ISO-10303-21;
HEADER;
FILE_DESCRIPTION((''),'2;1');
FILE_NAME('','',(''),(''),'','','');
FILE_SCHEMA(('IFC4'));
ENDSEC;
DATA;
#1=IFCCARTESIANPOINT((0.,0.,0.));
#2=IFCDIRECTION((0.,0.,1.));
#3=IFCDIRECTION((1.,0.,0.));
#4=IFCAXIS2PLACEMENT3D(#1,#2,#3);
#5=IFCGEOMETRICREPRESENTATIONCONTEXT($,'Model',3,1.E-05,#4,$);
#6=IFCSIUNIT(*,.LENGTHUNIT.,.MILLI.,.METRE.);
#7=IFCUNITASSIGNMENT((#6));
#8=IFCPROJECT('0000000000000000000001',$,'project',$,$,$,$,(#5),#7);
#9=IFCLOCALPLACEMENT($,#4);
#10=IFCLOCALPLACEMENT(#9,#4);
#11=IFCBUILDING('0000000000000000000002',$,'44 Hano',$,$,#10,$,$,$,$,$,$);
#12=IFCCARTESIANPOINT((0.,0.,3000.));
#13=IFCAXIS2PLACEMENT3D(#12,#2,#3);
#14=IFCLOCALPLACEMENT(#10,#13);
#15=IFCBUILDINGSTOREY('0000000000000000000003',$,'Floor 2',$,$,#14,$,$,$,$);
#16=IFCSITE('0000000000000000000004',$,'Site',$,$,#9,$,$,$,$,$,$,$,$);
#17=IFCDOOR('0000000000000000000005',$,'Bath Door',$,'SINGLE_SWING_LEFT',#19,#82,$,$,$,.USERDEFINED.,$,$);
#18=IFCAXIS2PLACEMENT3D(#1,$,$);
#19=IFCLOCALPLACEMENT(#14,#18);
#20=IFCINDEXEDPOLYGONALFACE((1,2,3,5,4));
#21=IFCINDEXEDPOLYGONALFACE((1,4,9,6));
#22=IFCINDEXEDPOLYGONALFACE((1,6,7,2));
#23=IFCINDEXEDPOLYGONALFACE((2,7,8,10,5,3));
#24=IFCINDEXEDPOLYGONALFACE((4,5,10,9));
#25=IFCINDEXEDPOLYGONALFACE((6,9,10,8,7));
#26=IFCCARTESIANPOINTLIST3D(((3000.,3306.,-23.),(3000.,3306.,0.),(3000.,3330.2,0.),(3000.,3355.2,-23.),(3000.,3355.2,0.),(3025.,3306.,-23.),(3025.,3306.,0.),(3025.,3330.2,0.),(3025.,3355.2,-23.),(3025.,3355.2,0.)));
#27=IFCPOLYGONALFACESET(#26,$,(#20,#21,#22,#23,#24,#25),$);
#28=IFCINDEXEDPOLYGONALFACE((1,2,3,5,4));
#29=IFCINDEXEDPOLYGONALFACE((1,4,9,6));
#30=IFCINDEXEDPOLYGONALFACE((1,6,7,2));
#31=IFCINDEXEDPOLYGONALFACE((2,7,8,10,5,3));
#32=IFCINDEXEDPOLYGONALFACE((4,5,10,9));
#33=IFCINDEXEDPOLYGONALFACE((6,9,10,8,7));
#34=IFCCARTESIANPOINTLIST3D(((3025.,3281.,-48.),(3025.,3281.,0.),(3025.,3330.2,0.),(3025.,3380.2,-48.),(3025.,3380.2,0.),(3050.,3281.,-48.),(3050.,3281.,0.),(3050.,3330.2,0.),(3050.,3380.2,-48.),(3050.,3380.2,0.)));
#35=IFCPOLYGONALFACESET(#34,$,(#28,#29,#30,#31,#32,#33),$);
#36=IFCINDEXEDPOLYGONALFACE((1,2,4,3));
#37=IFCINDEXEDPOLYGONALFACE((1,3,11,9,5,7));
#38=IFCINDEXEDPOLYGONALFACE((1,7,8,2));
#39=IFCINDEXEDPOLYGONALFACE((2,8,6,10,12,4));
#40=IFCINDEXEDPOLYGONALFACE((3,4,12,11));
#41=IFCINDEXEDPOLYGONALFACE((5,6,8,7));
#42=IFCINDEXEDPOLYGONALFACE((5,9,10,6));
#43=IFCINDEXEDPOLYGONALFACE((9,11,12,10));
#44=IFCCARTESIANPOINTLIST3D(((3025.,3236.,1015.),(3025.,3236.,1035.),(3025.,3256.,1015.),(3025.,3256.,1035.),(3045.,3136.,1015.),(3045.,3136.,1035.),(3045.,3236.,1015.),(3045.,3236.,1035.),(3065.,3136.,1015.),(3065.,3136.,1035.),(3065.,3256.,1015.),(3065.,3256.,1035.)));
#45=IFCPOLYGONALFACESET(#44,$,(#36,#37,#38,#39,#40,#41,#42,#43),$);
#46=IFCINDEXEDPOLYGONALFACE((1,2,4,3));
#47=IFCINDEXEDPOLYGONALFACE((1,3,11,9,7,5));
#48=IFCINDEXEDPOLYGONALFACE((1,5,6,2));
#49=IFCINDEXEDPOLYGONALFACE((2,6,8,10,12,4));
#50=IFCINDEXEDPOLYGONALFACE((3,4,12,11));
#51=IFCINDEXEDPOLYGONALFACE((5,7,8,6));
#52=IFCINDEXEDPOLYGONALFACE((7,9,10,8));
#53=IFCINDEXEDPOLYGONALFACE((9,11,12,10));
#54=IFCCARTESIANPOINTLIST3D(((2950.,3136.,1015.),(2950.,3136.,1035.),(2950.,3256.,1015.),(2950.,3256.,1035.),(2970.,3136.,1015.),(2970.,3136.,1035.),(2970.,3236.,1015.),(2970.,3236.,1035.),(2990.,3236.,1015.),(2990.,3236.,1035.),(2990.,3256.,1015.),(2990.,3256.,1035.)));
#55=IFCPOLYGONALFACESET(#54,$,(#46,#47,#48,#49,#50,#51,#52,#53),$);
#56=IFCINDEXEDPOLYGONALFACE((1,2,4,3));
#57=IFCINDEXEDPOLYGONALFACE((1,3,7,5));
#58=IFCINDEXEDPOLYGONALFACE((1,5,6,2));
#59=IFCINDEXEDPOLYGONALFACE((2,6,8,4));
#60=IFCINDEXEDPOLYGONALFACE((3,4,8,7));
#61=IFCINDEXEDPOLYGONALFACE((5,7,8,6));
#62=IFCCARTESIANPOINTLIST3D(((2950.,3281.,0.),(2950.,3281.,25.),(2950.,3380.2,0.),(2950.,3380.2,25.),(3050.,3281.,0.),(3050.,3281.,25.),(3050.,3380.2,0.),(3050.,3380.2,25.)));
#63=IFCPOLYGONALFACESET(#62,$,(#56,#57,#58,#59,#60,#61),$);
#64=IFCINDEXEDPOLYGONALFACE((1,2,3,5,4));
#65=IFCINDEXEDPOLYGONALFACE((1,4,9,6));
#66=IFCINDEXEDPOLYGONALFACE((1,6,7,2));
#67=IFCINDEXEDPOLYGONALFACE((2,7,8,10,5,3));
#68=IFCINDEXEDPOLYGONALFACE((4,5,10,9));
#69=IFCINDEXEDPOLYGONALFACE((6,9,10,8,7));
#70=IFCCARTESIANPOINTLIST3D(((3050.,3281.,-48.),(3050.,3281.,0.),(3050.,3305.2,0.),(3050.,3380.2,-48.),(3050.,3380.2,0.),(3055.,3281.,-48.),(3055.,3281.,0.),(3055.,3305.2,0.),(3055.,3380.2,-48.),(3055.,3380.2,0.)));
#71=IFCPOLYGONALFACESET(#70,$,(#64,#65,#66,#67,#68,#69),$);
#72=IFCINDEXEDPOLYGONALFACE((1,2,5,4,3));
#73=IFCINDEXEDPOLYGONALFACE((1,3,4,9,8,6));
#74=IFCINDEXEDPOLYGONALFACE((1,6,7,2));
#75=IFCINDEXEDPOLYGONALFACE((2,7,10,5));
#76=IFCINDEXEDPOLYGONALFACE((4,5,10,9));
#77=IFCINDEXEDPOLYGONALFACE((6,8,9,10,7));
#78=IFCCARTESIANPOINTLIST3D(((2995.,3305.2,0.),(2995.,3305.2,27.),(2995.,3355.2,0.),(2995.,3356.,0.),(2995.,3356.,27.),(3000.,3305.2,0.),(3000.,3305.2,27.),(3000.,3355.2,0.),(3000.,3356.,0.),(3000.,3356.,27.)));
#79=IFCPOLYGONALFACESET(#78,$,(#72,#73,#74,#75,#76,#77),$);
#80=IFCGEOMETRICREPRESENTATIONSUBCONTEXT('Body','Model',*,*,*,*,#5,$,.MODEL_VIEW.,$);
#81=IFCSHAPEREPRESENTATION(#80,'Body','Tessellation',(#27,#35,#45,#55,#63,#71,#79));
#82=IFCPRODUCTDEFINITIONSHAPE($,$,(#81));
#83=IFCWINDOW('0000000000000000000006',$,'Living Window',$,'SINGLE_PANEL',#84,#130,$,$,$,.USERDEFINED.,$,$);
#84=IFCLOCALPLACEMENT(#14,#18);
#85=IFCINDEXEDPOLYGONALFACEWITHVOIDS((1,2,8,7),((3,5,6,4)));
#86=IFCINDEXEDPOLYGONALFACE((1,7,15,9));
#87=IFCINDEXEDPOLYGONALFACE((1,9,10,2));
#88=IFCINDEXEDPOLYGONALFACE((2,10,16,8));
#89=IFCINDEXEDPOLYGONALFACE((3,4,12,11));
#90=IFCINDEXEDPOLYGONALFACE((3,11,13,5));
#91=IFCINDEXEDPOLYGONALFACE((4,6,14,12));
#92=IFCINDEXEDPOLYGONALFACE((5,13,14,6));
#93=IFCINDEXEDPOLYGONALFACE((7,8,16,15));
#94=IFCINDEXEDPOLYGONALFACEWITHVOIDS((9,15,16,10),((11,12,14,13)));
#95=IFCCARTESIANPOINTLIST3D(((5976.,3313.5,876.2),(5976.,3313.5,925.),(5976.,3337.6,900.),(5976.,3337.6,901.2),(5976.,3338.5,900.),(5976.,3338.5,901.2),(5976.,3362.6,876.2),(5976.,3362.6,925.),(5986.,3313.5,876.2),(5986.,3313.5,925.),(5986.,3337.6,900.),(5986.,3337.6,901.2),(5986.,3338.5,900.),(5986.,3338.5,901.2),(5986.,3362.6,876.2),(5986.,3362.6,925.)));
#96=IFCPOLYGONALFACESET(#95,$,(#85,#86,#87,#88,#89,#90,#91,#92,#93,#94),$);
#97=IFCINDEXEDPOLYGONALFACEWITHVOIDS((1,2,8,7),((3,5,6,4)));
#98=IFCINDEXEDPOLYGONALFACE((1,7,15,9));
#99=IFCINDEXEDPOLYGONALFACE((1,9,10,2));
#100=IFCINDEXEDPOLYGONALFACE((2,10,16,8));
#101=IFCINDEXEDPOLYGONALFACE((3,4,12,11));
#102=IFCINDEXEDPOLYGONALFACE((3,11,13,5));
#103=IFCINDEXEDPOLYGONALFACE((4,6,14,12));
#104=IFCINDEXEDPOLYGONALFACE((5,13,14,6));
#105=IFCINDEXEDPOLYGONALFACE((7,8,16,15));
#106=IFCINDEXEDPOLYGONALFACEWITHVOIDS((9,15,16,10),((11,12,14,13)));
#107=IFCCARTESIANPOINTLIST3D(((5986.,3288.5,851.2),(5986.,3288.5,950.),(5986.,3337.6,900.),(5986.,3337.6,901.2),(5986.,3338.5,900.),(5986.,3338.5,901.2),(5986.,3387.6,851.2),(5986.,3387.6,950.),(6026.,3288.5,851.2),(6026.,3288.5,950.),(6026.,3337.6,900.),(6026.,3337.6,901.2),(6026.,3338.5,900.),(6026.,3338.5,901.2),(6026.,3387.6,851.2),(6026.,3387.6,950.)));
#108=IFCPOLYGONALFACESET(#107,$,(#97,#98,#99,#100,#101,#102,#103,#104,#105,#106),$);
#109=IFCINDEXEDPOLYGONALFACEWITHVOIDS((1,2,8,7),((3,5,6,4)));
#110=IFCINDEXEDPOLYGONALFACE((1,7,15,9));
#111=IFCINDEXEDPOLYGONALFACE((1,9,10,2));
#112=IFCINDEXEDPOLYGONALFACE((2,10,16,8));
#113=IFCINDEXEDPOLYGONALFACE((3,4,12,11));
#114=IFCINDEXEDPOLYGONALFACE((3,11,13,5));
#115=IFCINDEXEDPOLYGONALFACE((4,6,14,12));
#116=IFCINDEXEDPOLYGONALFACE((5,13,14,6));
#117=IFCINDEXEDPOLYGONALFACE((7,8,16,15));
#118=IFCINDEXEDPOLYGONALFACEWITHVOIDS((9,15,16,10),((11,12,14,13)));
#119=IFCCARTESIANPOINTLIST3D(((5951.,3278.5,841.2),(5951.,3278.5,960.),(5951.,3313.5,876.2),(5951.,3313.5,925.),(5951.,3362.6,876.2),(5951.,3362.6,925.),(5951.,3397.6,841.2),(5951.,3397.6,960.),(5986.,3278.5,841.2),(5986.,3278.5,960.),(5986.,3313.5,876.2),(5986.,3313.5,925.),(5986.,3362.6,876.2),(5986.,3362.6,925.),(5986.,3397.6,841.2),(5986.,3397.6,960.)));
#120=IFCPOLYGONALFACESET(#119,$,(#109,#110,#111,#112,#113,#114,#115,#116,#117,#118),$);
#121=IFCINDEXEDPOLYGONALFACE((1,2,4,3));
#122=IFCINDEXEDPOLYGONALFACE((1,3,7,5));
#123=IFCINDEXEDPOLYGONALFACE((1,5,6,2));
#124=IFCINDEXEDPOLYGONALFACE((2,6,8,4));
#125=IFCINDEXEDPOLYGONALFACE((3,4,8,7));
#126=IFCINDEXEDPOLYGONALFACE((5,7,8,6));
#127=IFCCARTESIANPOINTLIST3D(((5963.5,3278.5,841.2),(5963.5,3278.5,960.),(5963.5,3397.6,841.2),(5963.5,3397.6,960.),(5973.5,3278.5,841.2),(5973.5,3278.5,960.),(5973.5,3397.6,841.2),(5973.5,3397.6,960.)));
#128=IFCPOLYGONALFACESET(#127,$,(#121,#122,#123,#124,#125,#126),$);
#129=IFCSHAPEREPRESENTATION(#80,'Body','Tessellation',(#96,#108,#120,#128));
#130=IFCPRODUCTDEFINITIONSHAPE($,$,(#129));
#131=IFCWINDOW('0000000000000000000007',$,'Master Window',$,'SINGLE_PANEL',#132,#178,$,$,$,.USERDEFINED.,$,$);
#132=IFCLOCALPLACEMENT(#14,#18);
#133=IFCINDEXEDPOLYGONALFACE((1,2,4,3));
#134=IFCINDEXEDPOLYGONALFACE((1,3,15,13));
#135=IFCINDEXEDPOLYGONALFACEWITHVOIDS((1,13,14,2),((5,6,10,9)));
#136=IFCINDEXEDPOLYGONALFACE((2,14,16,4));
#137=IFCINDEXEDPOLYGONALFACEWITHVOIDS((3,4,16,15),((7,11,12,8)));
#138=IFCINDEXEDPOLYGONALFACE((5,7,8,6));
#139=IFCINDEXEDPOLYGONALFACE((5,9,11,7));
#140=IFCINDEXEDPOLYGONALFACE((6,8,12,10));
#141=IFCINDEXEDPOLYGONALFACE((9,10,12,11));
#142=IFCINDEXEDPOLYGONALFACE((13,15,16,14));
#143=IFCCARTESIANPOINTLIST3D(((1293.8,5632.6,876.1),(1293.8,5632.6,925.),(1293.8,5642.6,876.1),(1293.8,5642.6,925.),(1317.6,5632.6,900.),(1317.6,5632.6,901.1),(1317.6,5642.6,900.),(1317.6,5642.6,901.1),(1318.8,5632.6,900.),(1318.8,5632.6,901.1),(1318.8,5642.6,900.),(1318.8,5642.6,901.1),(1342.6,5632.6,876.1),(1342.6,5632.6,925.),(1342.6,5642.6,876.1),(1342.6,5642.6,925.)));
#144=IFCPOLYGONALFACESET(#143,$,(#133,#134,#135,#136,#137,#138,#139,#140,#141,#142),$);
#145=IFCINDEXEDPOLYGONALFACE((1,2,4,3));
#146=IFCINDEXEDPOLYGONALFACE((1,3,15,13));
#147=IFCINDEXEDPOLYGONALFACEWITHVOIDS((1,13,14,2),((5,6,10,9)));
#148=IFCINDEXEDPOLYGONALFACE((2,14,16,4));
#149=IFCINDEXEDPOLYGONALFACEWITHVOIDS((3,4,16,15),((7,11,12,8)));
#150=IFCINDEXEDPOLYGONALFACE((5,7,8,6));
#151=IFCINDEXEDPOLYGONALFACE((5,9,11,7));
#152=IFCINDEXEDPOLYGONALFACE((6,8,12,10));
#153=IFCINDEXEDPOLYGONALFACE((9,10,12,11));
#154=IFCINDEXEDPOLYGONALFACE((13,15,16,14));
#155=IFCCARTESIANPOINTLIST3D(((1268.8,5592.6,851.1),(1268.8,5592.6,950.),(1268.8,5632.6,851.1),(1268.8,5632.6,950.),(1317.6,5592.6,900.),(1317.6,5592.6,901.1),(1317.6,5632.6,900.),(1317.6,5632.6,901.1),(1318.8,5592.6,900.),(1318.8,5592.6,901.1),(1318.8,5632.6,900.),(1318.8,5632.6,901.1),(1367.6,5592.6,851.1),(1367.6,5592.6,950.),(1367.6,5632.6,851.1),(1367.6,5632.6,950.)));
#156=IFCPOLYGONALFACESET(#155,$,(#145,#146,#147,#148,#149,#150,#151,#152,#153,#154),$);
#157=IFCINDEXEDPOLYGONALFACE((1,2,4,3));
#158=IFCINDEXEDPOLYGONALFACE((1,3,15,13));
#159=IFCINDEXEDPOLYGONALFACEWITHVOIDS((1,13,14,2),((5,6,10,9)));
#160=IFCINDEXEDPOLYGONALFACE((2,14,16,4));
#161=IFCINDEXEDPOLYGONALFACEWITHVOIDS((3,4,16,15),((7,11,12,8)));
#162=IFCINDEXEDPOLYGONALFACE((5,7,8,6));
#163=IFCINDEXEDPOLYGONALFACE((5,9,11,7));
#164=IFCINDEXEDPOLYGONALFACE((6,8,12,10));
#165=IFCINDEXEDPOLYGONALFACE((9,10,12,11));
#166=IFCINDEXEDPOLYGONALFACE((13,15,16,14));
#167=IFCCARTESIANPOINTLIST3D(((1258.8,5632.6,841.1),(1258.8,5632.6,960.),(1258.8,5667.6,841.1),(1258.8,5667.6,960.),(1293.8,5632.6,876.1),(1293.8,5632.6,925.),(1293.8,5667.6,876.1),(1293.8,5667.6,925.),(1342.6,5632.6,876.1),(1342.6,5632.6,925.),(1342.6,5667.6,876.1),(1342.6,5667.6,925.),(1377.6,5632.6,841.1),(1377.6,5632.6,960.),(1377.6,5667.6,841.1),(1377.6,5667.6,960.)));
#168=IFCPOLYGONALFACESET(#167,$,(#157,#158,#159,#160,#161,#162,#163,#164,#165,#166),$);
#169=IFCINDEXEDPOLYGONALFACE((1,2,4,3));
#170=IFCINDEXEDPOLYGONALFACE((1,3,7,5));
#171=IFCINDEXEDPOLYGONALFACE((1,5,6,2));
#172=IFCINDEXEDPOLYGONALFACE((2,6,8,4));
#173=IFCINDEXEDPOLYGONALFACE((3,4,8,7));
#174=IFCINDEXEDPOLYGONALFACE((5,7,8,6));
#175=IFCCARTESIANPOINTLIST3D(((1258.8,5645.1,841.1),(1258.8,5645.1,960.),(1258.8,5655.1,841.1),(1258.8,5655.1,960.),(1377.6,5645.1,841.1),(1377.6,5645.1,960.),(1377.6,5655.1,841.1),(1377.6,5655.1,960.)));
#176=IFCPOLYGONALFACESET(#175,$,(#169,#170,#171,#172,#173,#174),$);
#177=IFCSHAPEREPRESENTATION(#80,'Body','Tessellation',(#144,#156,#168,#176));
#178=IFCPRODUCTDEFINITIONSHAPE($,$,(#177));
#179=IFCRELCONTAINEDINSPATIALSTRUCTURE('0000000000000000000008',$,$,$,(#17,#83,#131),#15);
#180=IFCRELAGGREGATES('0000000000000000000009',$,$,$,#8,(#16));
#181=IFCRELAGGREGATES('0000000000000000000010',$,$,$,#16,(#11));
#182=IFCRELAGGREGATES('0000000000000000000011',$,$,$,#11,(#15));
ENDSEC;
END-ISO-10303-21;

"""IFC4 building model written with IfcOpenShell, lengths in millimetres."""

from ifc_helpers import new_model, si_unit, frame, origin_with_axes, place, context, subcontext, project, spatial, line, indexed_curve, outline, extrude, element, save


model = new_model("IFC4")

# Units and contexts
model_context = context("Model", 3, precision=1e-05, world=origin_with_axes())
body_context = subcontext(model_context, "Body", "Model", "MODEL_VIEW")
ifc_project = project(units=[si_unit("LENGTHUNIT", "METRE", prefix="MILLI")], contexts=[model_context])

# Site, building, storey
site_placement = place(None, origin_with_axes())
site = spatial("IfcSite", under=ifc_project, at=site_placement, Name="Site")
building_placement = place(site_placement, origin_with_axes())
building = spatial("IfcBuilding", under=site, at=building_placement, Name="44 Hano")
storey_placement = place(building_placement, frame((0.0, 0.0, 3000.0), z_axis=(0.0, 0.0, 1.0), x_axis=(1.0, 0.0, 0.0)))
storey = spatial("IfcBuildingStorey", under=building, at=storey_placement, Name="Floor 2")

# Door
door_1_placement = place(storey_placement, frame((3050.0, 3330.2, 0.0), z_axis=(0.0, 0.0, 1.0), x_axis=(0.0, 1.0, 0.0)))
element("IfcDoor", 1, at=door_1_placement, inside=storey, Name="Bath Door", ObjectType="SINGLE_SWING_LEFT", PredefinedType="USERDEFINED", context=body_context, shape_type="SweptSolid", body=[
    extrude(outline(indexed_curve([(0.0, 0.0), (0.0, 2.0), (0.8, 2.0), (0.8, 0.0), (-24.2, 0.0), (-24.2, -23.0), (25.0, -23.0), (25.0, 0.0)], segments=[line(1, 2, 3, 4, 5, 6, 7, 8, 1)])), frame((0.0, 25.0, 0.0), z_axis=(0.0, -1.0, 0.0), x_axis=(1.0, 0.0, 0.0)), (0.0, 0.0, -1.0), 25.0),
    extrude(outline(indexed_curve([(0.0, 0.0), (0.0, 2.0), (0.8, 2.0), (0.8, 0.0), (-49.2, 0.0), (-49.2, -48.0), (50.0, -48.0), (50.0, 0.0)], segments=[line(1, 2, 3, 4, 5, 6, 7, 8, 1)])), frame((0.0, 0.0, 0.0), z_axis=(0.0, -1.0, 0.0), x_axis=(1.0, 0.0, 0.0)), (0.0, 0.0, -1.0), 25.0),
    extrude(outline(indexed_curve([(0.0, 0.0), (-49.2, 0.0), (-49.2, 35.0), (0.0, 35.0)], segments=[line(1, 2, 3, 4, 1)])), frame((25.0, 25.0, 25.0), z_axis=(0.0, 0.0, 1.0), x_axis=(1.0, 0.0, 0.0)), (0.0, 0.0, 1.0), -48.0),
    extrude(outline(indexed_curve([(0.0, 0.0), (0.0, -40.0), (-120.0, -40.0), (-120.0, -20.0), (-20.0, -20.0), (-20.0, 0.0)], segments=[line(1, 2, 3, 4, 5, 6, 1)])), frame((-74.2, 25.0, 1015.0), z_axis=(0.0, 0.0, 1.0), x_axis=(1.0, 0.0, 0.0)), (0.0, 0.0, 1.0), 20.0),
    extrude(outline(indexed_curve([(0.0, 0.0), (0.0, 40.0), (-120.0, 40.0), (-120.0, 20.0), (-20.0, 20.0), (-20.0, 0.0)], segments=[line(1, 2, 3, 4, 5, 6, 1)])), frame((-74.2, 60.0, 1015.0), z_axis=(0.0, 0.0, 1.0), x_axis=(1.0, 0.0, 0.0)), (0.0, 0.0, 1.0), 20.0),
    extrude(outline(indexed_curve([(0.0, 0.0), (-99.2, 0.0), (-99.2, 100.0), (0.0, 100.0)], segments=[line(1, 2, 3, 4, 1)])), frame((50.0, 0.0, 0.0), z_axis=(0.0, 0.0, 1.0), x_axis=(1.0, 0.0, 0.0)), (0.0, 0.0, 1.0), 25.0),
    extrude(outline(indexed_curve([(0.0, 0.0), (0.0, 27.0), (50.8, 27.0), (50.8, 0.0), (-24.2, 0.0), (-24.2, -48.0), (75.0, -48.0), (75.0, 0.0)], segments=[line(1, 2, 3, 4, 5, 6, 7, 8, 1)])), frame((-25.0, -5.0, 0.0), z_axis=(0.0, -1.0, 0.0), x_axis=(1.0, 0.0, 0.0)), (0.0, 0.0, -1.0), 5.0),
    extrude(outline(indexed_curve([(0.0, 0.0), (0.0, 27.0), (50.8, 27.0), (50.8, 0.0), (0.8, 0.0), (0.8, -23.0), (50.0, -23.0), (50.0, 0.0)], segments=[line(1, 2, 3, 4, 5, 6, 7, 8, 1)])), frame((-25.0, 50.0, 0.0), z_axis=(0.0, -1.0, 0.0), x_axis=(1.0, 0.0, 0.0)), (0.0, 0.0, -1.0), 5.0),
])

# Windows
window_1_placement = place(storey_placement, frame((6076.0, 3337.6, 900.0), z_axis=(0.0, 0.0, 1.0), x_axis=(0.0, 1.0, 0.0)))
element("IfcWindow", 2, at=window_1_placement, inside=storey, Name="Living Window", ObjectType="SINGLE_PANEL", PredefinedType="USERDEFINED", context=body_context, shape_type="SweptSolid", body=[
    extrude(outline(indexed_curve([(0.0, 0.0), (0.9, 0.0), (0.9, 1.2), (0.0, 1.2)], segments=[line(1, 2, 3, 4, 1)]), holes=[indexed_curve([(25.0, 25.0), (-24.1, 25.0), (-24.1, -23.8), (25.0, -23.8)], segments=[line(1, 2, 3, 4, 1)])]), frame((0.0, 90.0, 0.0), z_axis=(0.0, -1.0, 0.0), x_axis=(1.0, 0.0, 0.0)), (0.0, 0.0, -1.0), 10.0),
    extrude(outline(indexed_curve([(0.0, 0.0), (0.9, 0.0), (0.9, 1.2), (0.0, 1.2)], segments=[line(1, 2, 3, 4, 1)]), holes=[indexed_curve([(50.0, 50.0), (-49.1, 50.0), (-49.1, -48.8), (50.0, -48.8)], segments=[line(1, 2, 3, 4, 1)])]), frame((0.0, 50.0, 0.0), z_axis=(0.0, -1.0, 0.0), x_axis=(1.0, 0.0, 0.0)), (0.0, 0.0, -1.0), 40.0),
    extrude(outline(indexed_curve([(0.0, 0.0), (-49.1, 0.0), (-49.1, -48.8), (0.0, -48.8)], segments=[line(1, 2, 3, 4, 1)]), holes=[indexed_curve([(35.0, 35.0), (-84.1, 35.0), (-84.1, -83.8), (35.0, -83.8)], segments=[line(1, 2, 3, 4, 1)])]), frame((25.0, 90.0, 25.0), z_axis=(0.0, -1.0, 0.0), x_axis=(1.0, 0.0, 0.0)), (0.0, 0.0, -1.0), 35.0),
    extrude(outline(indexed_curve([(35.0, 35.0), (-84.1, 35.0), (-84.1, -83.8), (35.0, -83.8)], segments=[line(1, 2, 3, 4, 1)])), frame((25.0, 102.5, 25.0), z_axis=(0.0, -1.0, 0.0), x_axis=(1.0, 0.0, 0.0)), (0.0, 0.0, -1.0), 10.0),
])
window_2_placement = place(storey_placement, frame((1317.6, 5542.6, 900.0), z_axis=(0.0, 0.0, 1.0), x_axis=(1.0, 0.0, 0.0)))
element("IfcWindow", 3, at=window_2_placement, inside=storey, Name="Master Window", ObjectType="SINGLE_PANEL", PredefinedType="USERDEFINED", context=body_context, shape_type="SweptSolid", body=[
    extrude(outline(indexed_curve([(0.0, 0.0), (1.2, 0.0), (1.2, 1.1), (0.0, 1.1)], segments=[line(1, 2, 3, 4, 1)]), holes=[indexed_curve([(25.0, 25.0), (-23.8, 25.0), (-23.8, -23.9), (25.0, -23.9)], segments=[line(1, 2, 3, 4, 1)])]), frame((0.0, 90.0, 0.0), z_axis=(0.0, -1.0, 0.0), x_axis=(1.0, 0.0, 0.0)), (0.0, 0.0, -1.0), 10.0),
    extrude(outline(indexed_curve([(0.0, 0.0), (1.2, 0.0), (1.2, 1.1), (0.0, 1.1)], segments=[line(1, 2, 3, 4, 1)]), holes=[indexed_curve([(50.0, 50.0), (-48.8, 50.0), (-48.8, -48.9), (50.0, -48.9)], segments=[line(1, 2, 3, 4, 1)])]), frame((0.0, 50.0, 0.0), z_axis=(0.0, -1.0, 0.0), x_axis=(1.0, 0.0, 0.0)), (0.0, 0.0, -1.0), 40.0),
    extrude(outline(indexed_curve([(0.0, 0.0), (-48.8, 0.0), (-48.8, -48.9), (0.0, -48.9)], segments=[line(1, 2, 3, 4, 1)]), holes=[indexed_curve([(35.0, 35.0), (-83.8, 35.0), (-83.8, -83.9), (35.0, -83.9)], segments=[line(1, 2, 3, 4, 1)])]), frame((25.0, 90.0, 25.0), z_axis=(0.0, -1.0, 0.0), x_axis=(1.0, 0.0, 0.0)), (0.0, 0.0, -1.0), 35.0),
    extrude(outline(indexed_curve([(35.0, 35.0), (-83.8, 35.0), (-83.8, -83.9), (35.0, -83.9)], segments=[line(1, 2, 3, 4, 1)])), frame((25.0, 102.5, 25.0), z_axis=(0.0, -1.0, 0.0), x_axis=(1.0, 0.0, 0.0)), (0.0, 0.0, -1.0), 10.0),
])

save(model, "model.ifc")
